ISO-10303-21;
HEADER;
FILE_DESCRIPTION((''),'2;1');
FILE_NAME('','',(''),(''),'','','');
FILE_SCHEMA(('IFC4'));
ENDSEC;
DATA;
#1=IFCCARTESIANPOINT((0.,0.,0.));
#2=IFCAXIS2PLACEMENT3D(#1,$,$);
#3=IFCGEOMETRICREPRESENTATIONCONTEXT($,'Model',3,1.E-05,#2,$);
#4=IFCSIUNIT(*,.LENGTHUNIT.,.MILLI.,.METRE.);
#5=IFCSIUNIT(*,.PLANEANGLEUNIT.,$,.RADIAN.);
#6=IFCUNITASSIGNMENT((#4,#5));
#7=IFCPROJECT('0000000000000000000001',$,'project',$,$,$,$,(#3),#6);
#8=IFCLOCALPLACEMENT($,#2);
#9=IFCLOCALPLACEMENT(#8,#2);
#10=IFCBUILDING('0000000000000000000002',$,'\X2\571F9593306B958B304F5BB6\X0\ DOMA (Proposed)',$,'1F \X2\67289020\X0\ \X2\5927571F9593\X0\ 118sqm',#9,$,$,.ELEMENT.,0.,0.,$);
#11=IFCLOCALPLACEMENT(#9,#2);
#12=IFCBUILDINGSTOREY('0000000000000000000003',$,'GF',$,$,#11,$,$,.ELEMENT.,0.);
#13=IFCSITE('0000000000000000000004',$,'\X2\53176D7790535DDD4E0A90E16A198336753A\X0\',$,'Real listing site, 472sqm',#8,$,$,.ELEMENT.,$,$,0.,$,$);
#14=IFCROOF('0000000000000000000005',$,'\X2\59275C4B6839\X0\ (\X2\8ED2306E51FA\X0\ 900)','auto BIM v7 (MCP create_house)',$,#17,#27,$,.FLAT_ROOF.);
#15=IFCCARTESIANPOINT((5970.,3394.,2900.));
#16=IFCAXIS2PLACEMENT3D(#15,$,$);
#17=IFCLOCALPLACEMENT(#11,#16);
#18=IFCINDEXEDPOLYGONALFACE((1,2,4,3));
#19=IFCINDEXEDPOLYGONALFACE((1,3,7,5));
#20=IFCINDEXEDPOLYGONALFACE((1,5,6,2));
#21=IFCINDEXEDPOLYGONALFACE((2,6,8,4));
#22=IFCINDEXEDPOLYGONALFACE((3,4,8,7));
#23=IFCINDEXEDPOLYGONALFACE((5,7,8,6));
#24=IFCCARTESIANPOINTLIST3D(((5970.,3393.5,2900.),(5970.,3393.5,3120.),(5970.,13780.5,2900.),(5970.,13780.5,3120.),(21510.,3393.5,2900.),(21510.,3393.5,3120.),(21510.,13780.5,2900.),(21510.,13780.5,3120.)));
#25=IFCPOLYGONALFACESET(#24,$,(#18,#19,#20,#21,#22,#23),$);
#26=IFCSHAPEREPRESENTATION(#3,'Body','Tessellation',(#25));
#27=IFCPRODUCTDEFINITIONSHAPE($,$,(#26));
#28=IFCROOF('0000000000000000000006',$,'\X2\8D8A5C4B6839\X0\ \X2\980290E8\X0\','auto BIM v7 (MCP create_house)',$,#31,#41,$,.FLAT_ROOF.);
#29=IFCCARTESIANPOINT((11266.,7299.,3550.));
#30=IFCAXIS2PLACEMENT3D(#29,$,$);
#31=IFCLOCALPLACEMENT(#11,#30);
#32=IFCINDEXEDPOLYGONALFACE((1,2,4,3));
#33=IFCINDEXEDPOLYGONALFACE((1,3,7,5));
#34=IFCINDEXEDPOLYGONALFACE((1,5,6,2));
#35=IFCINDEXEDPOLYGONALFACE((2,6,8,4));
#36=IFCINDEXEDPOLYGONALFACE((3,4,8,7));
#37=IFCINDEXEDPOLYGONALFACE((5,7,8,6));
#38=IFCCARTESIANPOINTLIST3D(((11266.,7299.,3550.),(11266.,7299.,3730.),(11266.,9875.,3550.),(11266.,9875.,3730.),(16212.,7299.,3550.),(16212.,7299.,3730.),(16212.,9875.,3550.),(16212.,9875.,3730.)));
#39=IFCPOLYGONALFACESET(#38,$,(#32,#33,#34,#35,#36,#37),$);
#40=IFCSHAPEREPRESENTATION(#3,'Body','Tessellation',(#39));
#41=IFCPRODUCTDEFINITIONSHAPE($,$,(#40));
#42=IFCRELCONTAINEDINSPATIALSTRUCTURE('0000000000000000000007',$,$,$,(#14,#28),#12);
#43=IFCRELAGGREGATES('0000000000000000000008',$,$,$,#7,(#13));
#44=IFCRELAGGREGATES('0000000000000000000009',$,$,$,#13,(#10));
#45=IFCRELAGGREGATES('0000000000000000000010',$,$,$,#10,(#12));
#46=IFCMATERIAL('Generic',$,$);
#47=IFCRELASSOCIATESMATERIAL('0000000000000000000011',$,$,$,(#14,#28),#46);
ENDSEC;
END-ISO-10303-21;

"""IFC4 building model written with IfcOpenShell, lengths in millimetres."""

from ifc_helpers import new_model, si_unit, frame, frame_2d, origin, place, context, project, spatial, rectangle, extrude, material, element, save


model = new_model("IFC4")

# Units and contexts
model_context = context("Model", 3, precision=1e-05, world=origin())
ifc_project = project(units=[si_unit("LENGTHUNIT", "METRE", prefix="MILLI"), si_unit("PLANEANGLEUNIT", "RADIAN")], contexts=[model_context])

# Site, building, storey
site_placement = place(None, origin())
site = spatial("IfcSite", under=ifc_project, at=site_placement, Name="北海道川上郡標茶町", ObjectType="Real listing site, 472sqm", CompositionType="ELEMENT", RefElevation=0.0)
building_placement = place(site_placement, origin())
building = spatial("IfcBuilding", under=site, at=building_placement, Name="土間に開く家 DOMA (Proposed)", ObjectType="1F 木造 大土間 118sqm", CompositionType="ELEMENT", ElevationOfRefHeight=0.0, ElevationOfTerrain=0.0)
storey_placement = place(building_placement, origin())
storey = spatial("IfcBuildingStorey", under=building, at=storey_placement, Name="GF", CompositionType="ELEMENT", Elevation=0.0)

# Shared definitions
ifc_material = material(Name="Generic")

# Roofs
roof_1_placement = place(storey_placement, frame((5970.0, 3394.0, 2900.0)))
element("IfcRoof", 1, at=roof_1_placement, inside=storey, material=ifc_material, Name="大屋根 (軒の出 900)", Description="auto BIM v7 (MCP create_house)", PredefinedType="FLAT_ROOF", context=model_context, shape_type="SweptSolid", body=[
    extrude(rectangle(XDim=15540.0, YDim=10387.0, at=frame_2d((7770.0, 5193.0))), frame((5970.0, 3394.0, 2900.0)), (0.0, 0.0, 1.0), 220.0),
])
roof_2_placement = place(storey_placement, frame((11266.0, 7299.0, 3550.0)))
element("IfcRoof", 2, at=roof_2_placement, inside=storey, material=ifc_material, Name="越屋根 頂部", Description="auto BIM v7 (MCP create_house)", PredefinedType="FLAT_ROOF", context=model_context, shape_type="SweptSolid", body=[
    extrude(rectangle(XDim=4946.0, YDim=2576.0, at=frame_2d((2473.0, 1288.0))), frame((11266.0, 7299.0, 3550.0)), (0.0, 0.0, 1.0), 180.0),
])

save(model, "model.ifc")
